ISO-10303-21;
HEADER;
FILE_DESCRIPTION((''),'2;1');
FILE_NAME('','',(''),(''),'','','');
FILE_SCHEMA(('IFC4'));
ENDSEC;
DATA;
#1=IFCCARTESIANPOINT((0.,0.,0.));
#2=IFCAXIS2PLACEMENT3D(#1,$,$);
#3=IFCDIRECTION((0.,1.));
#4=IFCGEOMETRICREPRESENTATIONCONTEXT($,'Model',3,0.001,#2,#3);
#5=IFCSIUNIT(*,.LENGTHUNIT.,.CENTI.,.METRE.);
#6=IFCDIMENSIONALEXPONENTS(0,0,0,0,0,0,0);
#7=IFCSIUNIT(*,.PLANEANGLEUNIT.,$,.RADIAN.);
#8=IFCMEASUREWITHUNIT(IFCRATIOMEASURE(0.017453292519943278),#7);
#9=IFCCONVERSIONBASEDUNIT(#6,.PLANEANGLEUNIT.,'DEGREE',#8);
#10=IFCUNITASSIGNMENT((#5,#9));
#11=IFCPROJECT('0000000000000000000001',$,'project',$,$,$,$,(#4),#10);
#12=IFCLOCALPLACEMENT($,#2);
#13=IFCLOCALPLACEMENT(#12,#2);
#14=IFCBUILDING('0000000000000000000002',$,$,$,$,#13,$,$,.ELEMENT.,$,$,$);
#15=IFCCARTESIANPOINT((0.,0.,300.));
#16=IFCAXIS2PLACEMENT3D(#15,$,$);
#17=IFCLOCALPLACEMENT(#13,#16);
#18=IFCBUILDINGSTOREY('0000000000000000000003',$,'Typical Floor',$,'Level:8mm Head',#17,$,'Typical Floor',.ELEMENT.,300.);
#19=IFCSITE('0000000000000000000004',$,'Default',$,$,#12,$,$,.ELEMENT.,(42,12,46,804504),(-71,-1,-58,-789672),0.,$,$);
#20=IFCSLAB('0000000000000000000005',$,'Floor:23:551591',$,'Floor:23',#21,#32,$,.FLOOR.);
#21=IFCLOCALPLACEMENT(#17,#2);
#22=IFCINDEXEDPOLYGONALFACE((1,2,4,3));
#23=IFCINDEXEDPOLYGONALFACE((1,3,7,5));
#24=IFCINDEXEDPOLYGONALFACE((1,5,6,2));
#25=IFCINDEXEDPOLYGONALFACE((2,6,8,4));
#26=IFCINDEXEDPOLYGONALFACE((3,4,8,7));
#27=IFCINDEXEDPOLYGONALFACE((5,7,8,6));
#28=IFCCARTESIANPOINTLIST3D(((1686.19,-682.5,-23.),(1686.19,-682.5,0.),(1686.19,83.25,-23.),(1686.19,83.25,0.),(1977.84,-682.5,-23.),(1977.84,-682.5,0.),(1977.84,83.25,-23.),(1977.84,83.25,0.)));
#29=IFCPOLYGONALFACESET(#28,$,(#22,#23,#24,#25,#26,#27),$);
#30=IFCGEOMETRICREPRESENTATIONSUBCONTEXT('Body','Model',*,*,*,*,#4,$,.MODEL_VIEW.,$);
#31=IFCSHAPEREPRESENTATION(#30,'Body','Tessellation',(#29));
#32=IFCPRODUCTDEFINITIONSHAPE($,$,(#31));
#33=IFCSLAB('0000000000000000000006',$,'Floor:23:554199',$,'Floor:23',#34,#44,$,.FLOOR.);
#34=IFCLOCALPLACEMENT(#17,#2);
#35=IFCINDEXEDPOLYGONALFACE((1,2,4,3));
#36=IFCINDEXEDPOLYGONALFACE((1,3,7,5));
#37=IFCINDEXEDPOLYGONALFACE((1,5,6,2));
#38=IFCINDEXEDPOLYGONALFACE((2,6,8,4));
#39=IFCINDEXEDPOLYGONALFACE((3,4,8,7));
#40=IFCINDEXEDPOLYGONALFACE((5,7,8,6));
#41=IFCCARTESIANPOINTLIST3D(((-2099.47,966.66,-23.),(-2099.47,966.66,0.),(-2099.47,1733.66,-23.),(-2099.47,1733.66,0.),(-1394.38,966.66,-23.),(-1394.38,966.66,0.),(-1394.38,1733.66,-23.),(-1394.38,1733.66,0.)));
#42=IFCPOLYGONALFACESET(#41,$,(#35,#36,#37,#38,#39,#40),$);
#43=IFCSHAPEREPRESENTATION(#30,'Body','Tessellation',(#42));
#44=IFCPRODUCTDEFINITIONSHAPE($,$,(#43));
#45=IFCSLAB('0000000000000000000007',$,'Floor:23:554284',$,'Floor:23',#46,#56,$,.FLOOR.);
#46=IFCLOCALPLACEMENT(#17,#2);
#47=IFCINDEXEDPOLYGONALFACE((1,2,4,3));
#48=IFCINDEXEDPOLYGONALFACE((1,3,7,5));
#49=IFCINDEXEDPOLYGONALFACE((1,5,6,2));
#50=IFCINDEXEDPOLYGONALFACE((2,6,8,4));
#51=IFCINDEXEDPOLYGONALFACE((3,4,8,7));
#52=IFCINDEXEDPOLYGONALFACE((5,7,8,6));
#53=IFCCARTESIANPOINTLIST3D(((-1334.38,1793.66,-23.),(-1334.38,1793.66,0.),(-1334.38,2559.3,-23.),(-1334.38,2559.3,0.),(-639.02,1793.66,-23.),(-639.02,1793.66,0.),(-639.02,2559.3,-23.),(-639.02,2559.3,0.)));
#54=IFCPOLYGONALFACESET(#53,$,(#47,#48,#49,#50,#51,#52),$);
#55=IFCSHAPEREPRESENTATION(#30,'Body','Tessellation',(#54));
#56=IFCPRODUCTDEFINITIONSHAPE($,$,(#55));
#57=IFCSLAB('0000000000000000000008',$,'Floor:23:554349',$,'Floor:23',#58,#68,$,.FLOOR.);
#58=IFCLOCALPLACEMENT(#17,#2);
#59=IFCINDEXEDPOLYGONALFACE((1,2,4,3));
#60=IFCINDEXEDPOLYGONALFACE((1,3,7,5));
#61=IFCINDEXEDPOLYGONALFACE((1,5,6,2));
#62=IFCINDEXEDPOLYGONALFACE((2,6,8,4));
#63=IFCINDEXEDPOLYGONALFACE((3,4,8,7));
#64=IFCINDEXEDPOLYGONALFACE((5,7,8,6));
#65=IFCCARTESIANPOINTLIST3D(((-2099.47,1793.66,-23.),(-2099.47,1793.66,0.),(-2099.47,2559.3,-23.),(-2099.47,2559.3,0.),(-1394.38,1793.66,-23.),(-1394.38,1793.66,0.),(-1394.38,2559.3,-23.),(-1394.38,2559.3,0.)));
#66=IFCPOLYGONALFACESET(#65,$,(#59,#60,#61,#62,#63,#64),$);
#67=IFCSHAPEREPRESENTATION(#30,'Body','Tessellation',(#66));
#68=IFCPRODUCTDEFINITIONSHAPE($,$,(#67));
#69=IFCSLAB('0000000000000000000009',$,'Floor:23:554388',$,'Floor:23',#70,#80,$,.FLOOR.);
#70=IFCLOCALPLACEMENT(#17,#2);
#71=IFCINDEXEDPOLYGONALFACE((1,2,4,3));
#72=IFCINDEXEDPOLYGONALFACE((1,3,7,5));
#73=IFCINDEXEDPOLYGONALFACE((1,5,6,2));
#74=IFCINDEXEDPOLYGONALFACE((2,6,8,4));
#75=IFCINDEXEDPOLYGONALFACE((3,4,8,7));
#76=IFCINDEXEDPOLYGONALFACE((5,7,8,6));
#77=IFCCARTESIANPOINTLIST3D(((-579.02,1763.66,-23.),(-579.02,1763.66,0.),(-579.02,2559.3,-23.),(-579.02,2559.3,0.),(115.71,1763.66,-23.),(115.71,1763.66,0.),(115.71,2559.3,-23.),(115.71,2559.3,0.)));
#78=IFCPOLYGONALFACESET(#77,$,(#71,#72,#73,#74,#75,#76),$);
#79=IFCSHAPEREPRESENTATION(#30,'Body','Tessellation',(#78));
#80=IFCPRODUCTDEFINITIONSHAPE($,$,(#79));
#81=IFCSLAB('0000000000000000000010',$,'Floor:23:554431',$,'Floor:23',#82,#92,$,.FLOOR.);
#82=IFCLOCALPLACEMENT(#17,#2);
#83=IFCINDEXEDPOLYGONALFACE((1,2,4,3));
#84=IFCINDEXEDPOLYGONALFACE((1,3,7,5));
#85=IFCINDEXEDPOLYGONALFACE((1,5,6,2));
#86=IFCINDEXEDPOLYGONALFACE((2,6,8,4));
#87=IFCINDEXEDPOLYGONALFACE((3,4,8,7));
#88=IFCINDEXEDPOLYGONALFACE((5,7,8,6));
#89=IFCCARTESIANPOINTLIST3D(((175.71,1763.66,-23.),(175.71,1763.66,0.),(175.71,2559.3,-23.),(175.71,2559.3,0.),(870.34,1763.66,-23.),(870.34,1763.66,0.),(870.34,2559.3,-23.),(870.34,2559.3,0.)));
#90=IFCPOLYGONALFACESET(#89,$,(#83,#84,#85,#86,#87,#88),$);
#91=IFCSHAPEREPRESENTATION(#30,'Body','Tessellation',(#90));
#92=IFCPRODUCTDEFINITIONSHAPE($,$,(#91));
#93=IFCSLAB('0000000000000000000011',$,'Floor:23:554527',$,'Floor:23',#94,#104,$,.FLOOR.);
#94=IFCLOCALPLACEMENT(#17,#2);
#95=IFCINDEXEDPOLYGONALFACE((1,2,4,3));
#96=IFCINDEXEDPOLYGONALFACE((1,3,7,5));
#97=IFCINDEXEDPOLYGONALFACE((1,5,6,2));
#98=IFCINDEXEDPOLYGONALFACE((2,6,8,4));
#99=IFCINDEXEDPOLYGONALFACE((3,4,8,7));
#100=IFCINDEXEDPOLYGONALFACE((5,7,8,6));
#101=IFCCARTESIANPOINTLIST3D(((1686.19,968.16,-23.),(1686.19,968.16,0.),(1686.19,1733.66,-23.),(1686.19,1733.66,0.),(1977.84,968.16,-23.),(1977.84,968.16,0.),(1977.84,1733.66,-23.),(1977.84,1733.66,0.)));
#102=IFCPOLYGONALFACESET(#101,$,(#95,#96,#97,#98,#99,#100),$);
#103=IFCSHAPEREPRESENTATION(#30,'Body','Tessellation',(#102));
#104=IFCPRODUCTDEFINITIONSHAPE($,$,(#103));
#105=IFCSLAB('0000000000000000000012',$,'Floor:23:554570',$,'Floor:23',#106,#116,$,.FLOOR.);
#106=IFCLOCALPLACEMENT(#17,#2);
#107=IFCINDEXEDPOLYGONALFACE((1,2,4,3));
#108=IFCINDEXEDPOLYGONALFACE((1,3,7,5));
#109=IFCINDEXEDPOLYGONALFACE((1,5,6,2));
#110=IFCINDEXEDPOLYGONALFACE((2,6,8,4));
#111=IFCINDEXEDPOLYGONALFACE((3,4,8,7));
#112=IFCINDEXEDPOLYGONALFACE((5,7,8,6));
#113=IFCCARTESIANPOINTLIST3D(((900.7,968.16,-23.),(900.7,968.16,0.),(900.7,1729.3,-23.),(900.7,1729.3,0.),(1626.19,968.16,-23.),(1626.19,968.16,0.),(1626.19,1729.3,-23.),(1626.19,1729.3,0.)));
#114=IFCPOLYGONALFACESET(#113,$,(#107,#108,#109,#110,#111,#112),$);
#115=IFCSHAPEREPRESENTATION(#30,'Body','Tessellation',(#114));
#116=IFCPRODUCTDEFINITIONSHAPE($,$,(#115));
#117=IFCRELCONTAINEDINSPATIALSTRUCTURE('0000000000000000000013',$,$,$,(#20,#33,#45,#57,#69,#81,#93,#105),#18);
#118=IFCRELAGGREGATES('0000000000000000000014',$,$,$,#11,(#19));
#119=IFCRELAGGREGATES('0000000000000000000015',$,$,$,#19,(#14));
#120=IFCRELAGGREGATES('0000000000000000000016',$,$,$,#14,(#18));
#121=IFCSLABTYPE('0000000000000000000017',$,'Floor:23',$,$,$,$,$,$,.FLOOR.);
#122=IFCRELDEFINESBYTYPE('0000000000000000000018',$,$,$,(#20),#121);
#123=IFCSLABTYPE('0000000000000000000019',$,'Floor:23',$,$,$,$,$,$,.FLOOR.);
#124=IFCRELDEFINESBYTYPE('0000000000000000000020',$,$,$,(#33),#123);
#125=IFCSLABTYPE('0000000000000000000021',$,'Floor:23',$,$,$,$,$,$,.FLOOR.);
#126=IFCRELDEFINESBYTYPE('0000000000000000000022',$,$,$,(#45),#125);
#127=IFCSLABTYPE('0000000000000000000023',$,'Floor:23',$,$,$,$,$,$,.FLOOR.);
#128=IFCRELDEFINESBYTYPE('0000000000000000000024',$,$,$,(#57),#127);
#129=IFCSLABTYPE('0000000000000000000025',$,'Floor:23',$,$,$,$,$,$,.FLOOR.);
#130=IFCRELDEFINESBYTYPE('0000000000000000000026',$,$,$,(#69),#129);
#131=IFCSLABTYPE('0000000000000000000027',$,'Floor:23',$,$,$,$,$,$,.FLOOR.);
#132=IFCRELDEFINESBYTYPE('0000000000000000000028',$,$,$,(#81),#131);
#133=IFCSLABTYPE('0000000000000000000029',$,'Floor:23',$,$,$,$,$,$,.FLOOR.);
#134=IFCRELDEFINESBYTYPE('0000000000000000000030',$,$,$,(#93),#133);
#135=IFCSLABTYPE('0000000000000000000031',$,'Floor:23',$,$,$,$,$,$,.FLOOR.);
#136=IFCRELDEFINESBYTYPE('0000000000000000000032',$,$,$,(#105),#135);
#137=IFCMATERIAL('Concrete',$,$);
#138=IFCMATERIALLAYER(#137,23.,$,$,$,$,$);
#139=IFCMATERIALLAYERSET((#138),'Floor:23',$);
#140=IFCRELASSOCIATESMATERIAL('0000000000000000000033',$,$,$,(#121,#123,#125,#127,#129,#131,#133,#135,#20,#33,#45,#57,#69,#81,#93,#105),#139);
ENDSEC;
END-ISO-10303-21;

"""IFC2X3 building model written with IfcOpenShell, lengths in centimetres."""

from ifc_helpers import new_model, entity, si_unit, converted_unit, direction, frame, frame_2d, origin, origin_2d_with_axis, place, context, subcontext, project, spatial, rectangle, extrude, material, layer, layer_set, layer_usage, type_object, element, save


model = new_model("IFC2X3")

# Units and contexts
model_context = context("Model", 3, precision=0.001, world=origin(), true_north=direction((0.0, 1.0)))
body_context = subcontext(model_context, "Body", "Model", "MODEL_VIEW")
ifc_project = project(units=[si_unit("LENGTHUNIT", "METRE", prefix="CENTI"), converted_unit("PLANEANGLEUNIT", "DEGREE", entity("IfcRatioMeasure", 0.017453292519943278), si_unit("PLANEANGLEUNIT", "RADIAN"), dimensions=[0, 0, 0, 0, 0, 0, 0])], contexts=[model_context])

# Site, building, storey
site_placement = place(None, origin())
site = spatial("IfcSite", under=ifc_project, at=site_placement, Name="Default", CompositionType="ELEMENT", RefLatitude=(42, 12, 46, 804504), RefLongitude=(-71, -1, -58, -789672), RefElevation=0.0)
building_placement = place(site_placement, origin())
building = spatial("IfcBuilding", under=site, at=building_placement, CompositionType="ELEMENT")
storey_placement = place(building_placement, frame((0.0, 0.0, 300.0)))
storey = spatial("IfcBuildingStorey", under=building, at=storey_placement, Name="Typical Floor", ObjectType="Level:8mm Head", LongName="Typical Floor", CompositionType="ELEMENT", Elevation=300.0)

# Shared definitions
ifc_material = material(Name="Concrete")

# Slabs
ifc_layer = layer(ifc_material, 23.0)
ifc_layer_set = layer_set([ifc_layer], Name="Floor:23")
ifc_layer_usage_1 = layer_usage(ifc_layer_set, "AXIS3", "POSITIVE", 0.0)
slab_type_1 = type_object("IfcSlabType", Name="Floor:23", PredefinedType="FLOOR", material=ifc_layer_set)
slab_1_placement = place(storey_placement, origin())
element("IfcSlab", 1, at=slab_1_placement, inside=storey, type_object=slab_type_1, material=ifc_layer_usage_1, Name="Floor:23:551591", ObjectType="Floor:23", PredefinedType="FLOOR", context=body_context, shape_type="SweptSolid", body=[
    extrude(rectangle(XDim=765.75, YDim=291.65, at=frame_2d((0.0, 0.0), x_axis=(1.0, 0.0))), frame((1832.01, -299.63, 0.0), z_axis=(0.0, 0.0, -1.0), x_axis=(0.0, 1.0, 0.0)), (0.0, 0.0, 1.0), 23.0),
])
ifc_layer_usage_2 = layer_usage(ifc_layer_set, "AXIS3", "POSITIVE", 0.0)
slab_type_2 = type_object("IfcSlabType", Name="Floor:23", PredefinedType="FLOOR", material=ifc_layer_set)
slab_2_placement = place(storey_placement, origin())
element("IfcSlab", 2, at=slab_2_placement, inside=storey, type_object=slab_type_2, material=ifc_layer_usage_2, Name="Floor:23:554199", ObjectType="Floor:23", PredefinedType="FLOOR", context=body_context, shape_type="SweptSolid", body=[
    extrude(rectangle(XDim=767.0, YDim=705.09, at=frame_2d((0.0, 0.0), x_axis=(1.0, 0.0))), frame((-1746.93, 1350.16, 0.0), z_axis=(0.0, 0.0, -1.0), x_axis=(0.0, 1.0, 0.0)), (0.0, 0.0, 1.0), 23.0),
])
ifc_layer_usage_3 = layer_usage(ifc_layer_set, "AXIS3", "POSITIVE", 0.0)
slab_type_3 = type_object("IfcSlabType", Name="Floor:23", PredefinedType="FLOOR", material=ifc_layer_set)
slab_3_placement = place(storey_placement, origin())
element("IfcSlab", 3, at=slab_3_placement, inside=storey, type_object=slab_type_3, material=ifc_layer_usage_3, Name="Floor:23:554284", ObjectType="Floor:23", PredefinedType="FLOOR", context=body_context, shape_type="SweptSolid", body=[
    extrude(rectangle(XDim=765.63, YDim=695.37, at=frame_2d((0.0, 0.0), x_axis=(1.0, 0.0))), frame((-986.7, 2176.48, 0.0), z_axis=(0.0, 0.0, -1.0), x_axis=(0.0, 1.0, 0.0)), (0.0, 0.0, 1.0), 23.0),
])
ifc_layer_usage_4 = layer_usage(ifc_layer_set, "AXIS3", "POSITIVE", 0.0)
slab_type_4 = type_object("IfcSlabType", Name="Floor:23", PredefinedType="FLOOR", material=ifc_layer_set)
slab_4_placement = place(storey_placement, origin())
element("IfcSlab", 4, at=slab_4_placement, inside=storey, type_object=slab_type_4, material=ifc_layer_usage_4, Name="Floor:23:554349", ObjectType="Floor:23", PredefinedType="FLOOR", context=body_context, shape_type="SweptSolid", body=[
    extrude(rectangle(XDim=765.63, YDim=705.09, at=origin_2d_with_axis()), frame((-1746.93, 2176.48, 0.0), z_axis=(0.0, 0.0, -1.0), x_axis=(0.0, 1.0, 0.0)), (0.0, 0.0, 1.0), 23.0),
])
ifc_layer_usage_5 = layer_usage(ifc_layer_set, "AXIS3", "POSITIVE", 0.0)
slab_type_5 = type_object("IfcSlabType", Name="Floor:23", PredefinedType="FLOOR", material=ifc_layer_set)
slab_5_placement = place(storey_placement, origin())
element("IfcSlab", 5, at=slab_5_placement, inside=storey, type_object=slab_type_5, material=ifc_layer_usage_5, Name="Floor:23:554388", ObjectType="Floor:23", PredefinedType="FLOOR", context=body_context, shape_type="SweptSolid", body=[
    extrude(rectangle(XDim=795.63, YDim=694.72, at=frame_2d((0.0, 0.0), x_axis=(1.0, 0.0))), frame((-231.65, 2161.48, 0.0), z_axis=(0.0, 0.0, -1.0), x_axis=(0.0, 1.0, 0.0)), (0.0, 0.0, 1.0), 23.0),
])
ifc_layer_usage_6 = layer_usage(ifc_layer_set, "AXIS3", "POSITIVE", 0.0)
slab_type_6 = type_object("IfcSlabType", Name="Floor:23", PredefinedType="FLOOR", material=ifc_layer_set)
slab_6_placement = place(storey_placement, origin())
element("IfcSlab", 6, at=slab_6_placement, inside=storey, type_object=slab_type_6, material=ifc_layer_usage_6, Name="Floor:23:554431", ObjectType="Floor:23", PredefinedType="FLOOR", context=body_context, shape_type="SweptSolid", body=[
    extrude(rectangle(XDim=795.63, YDim=694.63, at=frame_2d((0.0, 0.0), x_axis=(1.0, 0.0))), frame((523.02, 2161.48, 0.0), z_axis=(0.0, 0.0, -1.0), x_axis=(0.0, 1.0, 0.0)), (0.0, 0.0, 1.0), 23.0),
])
ifc_layer_usage_7 = layer_usage(ifc_layer_set, "AXIS3", "POSITIVE", 0.0)
slab_type_7 = type_object("IfcSlabType", Name="Floor:23", PredefinedType="FLOOR", material=ifc_layer_set)
slab_7_placement = place(storey_placement, origin())
element("IfcSlab", 7, at=slab_7_placement, inside=storey, type_object=slab_type_7, material=ifc_layer_usage_7, Name="Floor:23:554527", ObjectType="Floor:23", PredefinedType="FLOOR", context=body_context, shape_type="SweptSolid", body=[
    extrude(rectangle(XDim=765.5, YDim=291.65, at=frame_2d((0.0, 0.0), x_axis=(1.0, 0.0))), frame((1832.01, 1350.91, 0.0), z_axis=(0.0, 0.0, -1.0), x_axis=(0.0, 1.0, 0.0)), (0.0, 0.0, 1.0), 23.0),
])
ifc_layer_usage_8 = layer_usage(ifc_layer_set, "AXIS3", "POSITIVE", 0.0)
slab_type_8 = type_object("IfcSlabType", Name="Floor:23", PredefinedType="FLOOR", material=ifc_layer_set)
slab_8_placement = place(storey_placement, origin())
element("IfcSlab", 8, at=slab_8_placement, inside=storey, type_object=slab_type_8, material=ifc_layer_usage_8, Name="Floor:23:554570", ObjectType="Floor:23", PredefinedType="FLOOR", context=body_context, shape_type="SweptSolid", body=[
    extrude(rectangle(XDim=761.14, YDim=725.49, at=frame_2d((0.0, 0.0), x_axis=(1.0, 0.0))), frame((1263.44, 1348.73, 0.0), z_axis=(0.0, 0.0, -1.0), x_axis=(0.0, 1.0, 0.0)), (0.0, 0.0, 1.0), 23.0),
])

save(model, "model.ifc")
